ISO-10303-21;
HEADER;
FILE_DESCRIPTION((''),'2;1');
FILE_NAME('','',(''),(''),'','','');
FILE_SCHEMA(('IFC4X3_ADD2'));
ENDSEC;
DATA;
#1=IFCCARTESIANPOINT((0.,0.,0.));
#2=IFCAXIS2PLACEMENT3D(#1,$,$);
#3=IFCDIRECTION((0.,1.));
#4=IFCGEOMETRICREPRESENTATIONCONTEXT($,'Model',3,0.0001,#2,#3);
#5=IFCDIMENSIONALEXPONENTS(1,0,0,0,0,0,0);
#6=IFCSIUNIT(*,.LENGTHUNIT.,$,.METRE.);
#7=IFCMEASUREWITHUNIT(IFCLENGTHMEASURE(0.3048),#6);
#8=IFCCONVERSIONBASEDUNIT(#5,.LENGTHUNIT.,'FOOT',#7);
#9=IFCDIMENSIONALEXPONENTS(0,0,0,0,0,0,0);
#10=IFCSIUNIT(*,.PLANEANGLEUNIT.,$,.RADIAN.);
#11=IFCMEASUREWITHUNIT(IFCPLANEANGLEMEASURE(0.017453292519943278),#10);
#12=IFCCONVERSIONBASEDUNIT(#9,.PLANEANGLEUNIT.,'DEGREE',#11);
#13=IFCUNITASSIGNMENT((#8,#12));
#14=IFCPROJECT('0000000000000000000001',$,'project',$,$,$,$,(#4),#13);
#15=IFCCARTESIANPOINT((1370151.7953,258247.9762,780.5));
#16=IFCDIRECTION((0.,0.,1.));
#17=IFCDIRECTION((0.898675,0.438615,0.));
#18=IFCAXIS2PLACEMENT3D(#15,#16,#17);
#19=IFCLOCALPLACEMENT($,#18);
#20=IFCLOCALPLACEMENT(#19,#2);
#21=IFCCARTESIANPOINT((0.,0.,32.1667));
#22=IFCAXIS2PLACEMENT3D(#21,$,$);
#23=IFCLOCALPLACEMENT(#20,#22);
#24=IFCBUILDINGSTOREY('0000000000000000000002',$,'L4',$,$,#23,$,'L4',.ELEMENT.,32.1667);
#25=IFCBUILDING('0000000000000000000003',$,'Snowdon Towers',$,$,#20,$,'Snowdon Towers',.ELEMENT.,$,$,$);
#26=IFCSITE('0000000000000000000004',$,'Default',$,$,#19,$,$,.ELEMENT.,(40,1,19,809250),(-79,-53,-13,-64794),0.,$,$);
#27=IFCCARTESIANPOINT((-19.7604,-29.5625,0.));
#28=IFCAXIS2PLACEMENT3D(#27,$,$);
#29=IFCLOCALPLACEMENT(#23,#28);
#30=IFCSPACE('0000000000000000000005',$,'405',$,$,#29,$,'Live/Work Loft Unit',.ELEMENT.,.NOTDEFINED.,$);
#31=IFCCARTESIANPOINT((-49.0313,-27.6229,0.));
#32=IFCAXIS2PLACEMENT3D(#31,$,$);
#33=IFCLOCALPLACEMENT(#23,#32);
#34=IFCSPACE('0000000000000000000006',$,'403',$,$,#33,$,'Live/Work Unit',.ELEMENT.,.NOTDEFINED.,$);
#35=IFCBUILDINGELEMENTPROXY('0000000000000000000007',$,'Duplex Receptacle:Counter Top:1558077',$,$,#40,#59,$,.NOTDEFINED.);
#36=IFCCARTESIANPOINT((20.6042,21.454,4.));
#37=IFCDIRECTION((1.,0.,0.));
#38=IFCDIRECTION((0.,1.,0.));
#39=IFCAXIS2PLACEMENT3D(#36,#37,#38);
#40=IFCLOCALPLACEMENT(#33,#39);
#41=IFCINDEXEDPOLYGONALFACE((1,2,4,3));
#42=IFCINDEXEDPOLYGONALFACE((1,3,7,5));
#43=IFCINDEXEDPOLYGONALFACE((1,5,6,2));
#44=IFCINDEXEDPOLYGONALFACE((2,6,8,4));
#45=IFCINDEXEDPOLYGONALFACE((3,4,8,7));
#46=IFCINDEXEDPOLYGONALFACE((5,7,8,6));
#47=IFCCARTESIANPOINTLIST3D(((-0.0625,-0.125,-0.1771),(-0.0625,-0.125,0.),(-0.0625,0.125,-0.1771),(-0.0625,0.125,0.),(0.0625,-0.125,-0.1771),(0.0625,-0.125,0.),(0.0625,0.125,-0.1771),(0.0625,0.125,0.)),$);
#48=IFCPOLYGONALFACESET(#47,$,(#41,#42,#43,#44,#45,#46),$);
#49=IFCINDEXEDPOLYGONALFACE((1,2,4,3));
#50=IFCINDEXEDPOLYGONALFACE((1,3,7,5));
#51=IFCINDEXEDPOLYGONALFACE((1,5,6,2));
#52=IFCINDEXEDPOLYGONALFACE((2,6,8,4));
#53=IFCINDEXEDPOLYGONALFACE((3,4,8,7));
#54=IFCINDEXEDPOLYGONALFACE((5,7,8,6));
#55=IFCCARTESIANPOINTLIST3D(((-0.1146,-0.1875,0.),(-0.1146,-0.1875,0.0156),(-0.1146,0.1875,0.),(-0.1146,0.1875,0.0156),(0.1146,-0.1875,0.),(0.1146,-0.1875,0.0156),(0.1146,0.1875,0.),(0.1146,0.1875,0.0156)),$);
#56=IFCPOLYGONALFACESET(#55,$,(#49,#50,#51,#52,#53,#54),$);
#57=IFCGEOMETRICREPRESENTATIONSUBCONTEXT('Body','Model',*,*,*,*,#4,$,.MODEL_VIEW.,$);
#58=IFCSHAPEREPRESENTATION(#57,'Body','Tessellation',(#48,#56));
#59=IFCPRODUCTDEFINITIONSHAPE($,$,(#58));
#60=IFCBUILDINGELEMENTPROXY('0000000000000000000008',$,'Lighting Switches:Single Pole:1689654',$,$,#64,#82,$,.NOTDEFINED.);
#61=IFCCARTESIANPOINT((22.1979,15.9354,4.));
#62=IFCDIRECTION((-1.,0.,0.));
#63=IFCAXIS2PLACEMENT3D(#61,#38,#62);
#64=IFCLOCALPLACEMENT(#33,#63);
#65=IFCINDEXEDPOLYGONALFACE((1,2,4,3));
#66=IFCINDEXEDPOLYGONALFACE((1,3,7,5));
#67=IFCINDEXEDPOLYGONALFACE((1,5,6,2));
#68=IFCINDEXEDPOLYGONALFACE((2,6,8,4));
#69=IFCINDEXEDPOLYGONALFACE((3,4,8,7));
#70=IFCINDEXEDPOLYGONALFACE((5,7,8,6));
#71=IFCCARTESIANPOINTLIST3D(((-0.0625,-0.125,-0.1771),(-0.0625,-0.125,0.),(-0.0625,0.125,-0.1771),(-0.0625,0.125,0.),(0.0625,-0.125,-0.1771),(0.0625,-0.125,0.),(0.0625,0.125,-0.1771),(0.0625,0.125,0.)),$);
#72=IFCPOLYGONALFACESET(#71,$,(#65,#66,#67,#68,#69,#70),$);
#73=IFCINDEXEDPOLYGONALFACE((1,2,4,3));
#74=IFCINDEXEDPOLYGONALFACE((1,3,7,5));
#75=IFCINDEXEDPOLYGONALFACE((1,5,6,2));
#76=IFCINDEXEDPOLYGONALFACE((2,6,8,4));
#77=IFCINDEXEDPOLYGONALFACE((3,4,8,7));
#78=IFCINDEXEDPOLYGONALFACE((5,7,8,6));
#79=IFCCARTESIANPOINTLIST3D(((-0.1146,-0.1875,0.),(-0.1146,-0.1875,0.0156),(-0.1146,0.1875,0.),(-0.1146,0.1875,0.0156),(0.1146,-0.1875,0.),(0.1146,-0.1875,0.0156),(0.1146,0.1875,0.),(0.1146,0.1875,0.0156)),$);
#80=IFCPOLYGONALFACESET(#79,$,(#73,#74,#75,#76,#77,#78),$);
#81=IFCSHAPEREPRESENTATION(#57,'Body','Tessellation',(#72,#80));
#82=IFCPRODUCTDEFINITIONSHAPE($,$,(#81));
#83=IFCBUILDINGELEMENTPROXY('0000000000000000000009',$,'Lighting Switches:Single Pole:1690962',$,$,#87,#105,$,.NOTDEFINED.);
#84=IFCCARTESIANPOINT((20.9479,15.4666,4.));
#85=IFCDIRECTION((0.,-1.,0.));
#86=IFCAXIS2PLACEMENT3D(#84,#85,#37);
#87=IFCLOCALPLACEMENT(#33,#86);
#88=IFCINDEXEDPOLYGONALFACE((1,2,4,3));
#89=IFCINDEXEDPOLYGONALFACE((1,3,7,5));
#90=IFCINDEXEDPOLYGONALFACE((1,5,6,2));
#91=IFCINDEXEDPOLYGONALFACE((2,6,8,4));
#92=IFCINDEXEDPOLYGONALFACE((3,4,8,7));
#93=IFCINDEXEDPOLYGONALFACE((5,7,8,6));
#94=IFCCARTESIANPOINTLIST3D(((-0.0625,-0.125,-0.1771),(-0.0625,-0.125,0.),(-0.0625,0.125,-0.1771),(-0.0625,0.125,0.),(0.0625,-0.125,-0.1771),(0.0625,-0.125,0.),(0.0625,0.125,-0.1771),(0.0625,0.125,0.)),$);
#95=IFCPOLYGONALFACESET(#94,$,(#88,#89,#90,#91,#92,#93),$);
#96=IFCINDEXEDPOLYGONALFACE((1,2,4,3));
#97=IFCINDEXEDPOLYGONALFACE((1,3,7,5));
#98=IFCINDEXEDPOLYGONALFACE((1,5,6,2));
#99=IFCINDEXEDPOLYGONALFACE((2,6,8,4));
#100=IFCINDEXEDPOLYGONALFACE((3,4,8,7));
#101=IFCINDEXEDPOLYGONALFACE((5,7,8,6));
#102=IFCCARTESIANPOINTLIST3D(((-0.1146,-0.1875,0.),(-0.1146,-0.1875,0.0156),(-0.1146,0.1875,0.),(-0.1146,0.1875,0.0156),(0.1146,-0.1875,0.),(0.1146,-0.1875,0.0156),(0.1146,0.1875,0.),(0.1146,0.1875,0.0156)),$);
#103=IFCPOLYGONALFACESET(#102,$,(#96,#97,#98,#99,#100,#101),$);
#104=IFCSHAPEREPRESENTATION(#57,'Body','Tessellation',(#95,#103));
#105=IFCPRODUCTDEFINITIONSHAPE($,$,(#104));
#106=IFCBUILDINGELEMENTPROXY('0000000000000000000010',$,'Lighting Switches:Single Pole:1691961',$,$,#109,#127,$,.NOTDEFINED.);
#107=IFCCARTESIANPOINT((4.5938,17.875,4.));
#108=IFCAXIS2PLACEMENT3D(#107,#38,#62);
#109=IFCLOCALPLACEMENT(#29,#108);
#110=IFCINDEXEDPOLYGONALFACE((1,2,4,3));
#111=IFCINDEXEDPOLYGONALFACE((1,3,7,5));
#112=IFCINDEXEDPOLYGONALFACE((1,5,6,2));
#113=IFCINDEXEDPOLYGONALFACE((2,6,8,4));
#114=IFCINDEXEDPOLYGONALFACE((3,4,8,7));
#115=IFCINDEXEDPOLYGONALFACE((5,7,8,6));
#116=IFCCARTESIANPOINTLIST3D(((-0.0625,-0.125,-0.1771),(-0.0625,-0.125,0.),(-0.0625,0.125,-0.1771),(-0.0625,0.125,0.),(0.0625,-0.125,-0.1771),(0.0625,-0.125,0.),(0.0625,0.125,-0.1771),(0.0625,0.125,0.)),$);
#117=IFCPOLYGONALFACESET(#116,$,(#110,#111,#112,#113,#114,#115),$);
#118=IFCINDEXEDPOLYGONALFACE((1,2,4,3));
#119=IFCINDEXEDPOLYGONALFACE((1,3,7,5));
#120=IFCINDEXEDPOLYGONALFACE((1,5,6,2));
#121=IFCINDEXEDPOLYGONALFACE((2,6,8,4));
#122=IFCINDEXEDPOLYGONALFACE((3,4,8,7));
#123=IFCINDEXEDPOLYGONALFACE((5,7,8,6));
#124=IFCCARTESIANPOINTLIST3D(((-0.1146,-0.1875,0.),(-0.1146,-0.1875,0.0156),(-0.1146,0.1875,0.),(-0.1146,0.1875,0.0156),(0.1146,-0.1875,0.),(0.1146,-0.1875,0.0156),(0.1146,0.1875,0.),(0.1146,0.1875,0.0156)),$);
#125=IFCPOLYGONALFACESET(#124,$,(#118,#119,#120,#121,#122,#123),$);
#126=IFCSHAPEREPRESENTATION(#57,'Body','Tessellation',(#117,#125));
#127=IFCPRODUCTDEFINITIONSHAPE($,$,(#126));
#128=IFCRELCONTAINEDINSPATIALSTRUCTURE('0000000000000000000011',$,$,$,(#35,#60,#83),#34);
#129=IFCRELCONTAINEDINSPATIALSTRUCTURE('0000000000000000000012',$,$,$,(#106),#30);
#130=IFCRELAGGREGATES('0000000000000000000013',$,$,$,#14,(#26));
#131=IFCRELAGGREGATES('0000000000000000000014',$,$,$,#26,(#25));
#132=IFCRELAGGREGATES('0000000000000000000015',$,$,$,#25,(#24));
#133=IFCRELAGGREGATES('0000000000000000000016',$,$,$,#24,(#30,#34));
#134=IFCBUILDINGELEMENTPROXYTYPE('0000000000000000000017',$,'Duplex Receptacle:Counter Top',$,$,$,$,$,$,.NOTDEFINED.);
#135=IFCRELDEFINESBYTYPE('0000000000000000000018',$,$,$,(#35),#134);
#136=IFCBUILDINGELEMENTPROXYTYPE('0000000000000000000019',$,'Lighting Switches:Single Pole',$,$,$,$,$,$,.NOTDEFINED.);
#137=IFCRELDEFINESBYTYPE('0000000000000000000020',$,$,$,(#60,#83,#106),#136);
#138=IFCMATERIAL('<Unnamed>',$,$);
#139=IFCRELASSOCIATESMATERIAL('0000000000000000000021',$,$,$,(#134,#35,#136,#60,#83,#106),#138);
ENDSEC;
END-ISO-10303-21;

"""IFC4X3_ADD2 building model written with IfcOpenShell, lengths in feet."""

from ifc_helpers import new_model, entity, si_unit, converted_unit, direction, frame, frame_2d, origin, origin_2d_with_axis, place, context, subcontext, project, spatial, rectangle, extrude, source, transform, mapped, material, type_object, type_shapes, element, save


model = new_model("IFC4X3_ADD2")

# Units and contexts
model_context = context("Model", 3, precision=0.0001, world=origin(), true_north=direction((0.0, 1.0)))
body_context = subcontext(model_context, "Body", "Model", "MODEL_VIEW")
ifc_project = project(units=[converted_unit("LENGTHUNIT", "FOOT", entity("IfcLengthMeasure", 0.3048), si_unit("LENGTHUNIT", "METRE"), dimensions=[1, 0, 0, 0, 0, 0, 0]), converted_unit("PLANEANGLEUNIT", "DEGREE", entity("IfcPlaneAngleMeasure", 0.017453292519943278), si_unit("PLANEANGLEUNIT", "RADIAN"), dimensions=[0, 0, 0, 0, 0, 0, 0])], contexts=[model_context])

# Site, building, storey, space
site_placement = place(None, frame((1370151.7953, 258247.9762, 780.5), z_axis=(0.0, 0.0, 1.0), x_axis=(0.898675, 0.438615, 0.0)))
site = spatial("IfcSite", under=ifc_project, at=site_placement, Name="Default", CompositionType="ELEMENT", RefLatitude=(40, 1, 19, 809250), RefLongitude=(-79, -53, -13, -64794), RefElevation=0.0)
building_placement = place(site_placement, origin())
building = spatial("IfcBuilding", under=site, at=building_placement, Name="Snowdon Towers", LongName="Snowdon Towers", CompositionType="ELEMENT")
storey_placement = place(building_placement, frame((0.0, 0.0, 32.1667)))
storey = spatial("IfcBuildingStorey", under=building, at=storey_placement, Name="L4", LongName="L4", CompositionType="ELEMENT", Elevation=32.1667)
space_1_placement = place(storey_placement, frame((-19.7604, -29.5625, 0.0)))
space_1 = spatial("IfcSpace", under=storey, at=space_1_placement, Name="405", LongName="Live/Work Loft Unit", CompositionType="ELEMENT", PredefinedType="NOTDEFINED")

# Shared definitions
ifc_material_1 = material(Name="<Unnamed>")

# Shared definitions
space_2_placement = place(storey_placement, frame((-49.0313, -27.6229, 0.0)))
space_2 = spatial("IfcSpace", under=storey, at=space_2_placement, Name="403", LongName="Live/Work Unit", CompositionType="ELEMENT", PredefinedType="NOTDEFINED")

# Building element proxies
building_element_proxy_type_1 = type_object("IfcBuildingElementProxyType", Name="Duplex Receptacle:Counter Top", PredefinedType="NOTDEFINED", material=ifc_material_1)
shared_shape_1 = source(origin(), body_context, "Body", "SweptSolid", [
    extrude(rectangle(XDim=0.125, YDim=0.25, at=origin_2d_with_axis()), frame((0.0, 0.0, -0.1771), z_axis=(0.0, 0.0, 1.0), x_axis=(-1.0, 0.0, 0.0)), (0.0, 0.0, 1.0), 0.1771),
    extrude(rectangle(XDim=0.2292, YDim=0.375, at=frame_2d((0.0, 0.0), x_axis=(1.0, 0.0))), frame((0.0, 0.0, 0.0), z_axis=(0.0, 0.0, 1.0), x_axis=(-1.0, 0.0, 0.0)), (0.0, 0.0, 1.0), 0.0156),
])
type_shapes(building_element_proxy_type_1, [shared_shape_1])
proxy_1_placement = place(space_2_placement, frame((20.6042, 21.454, 4.0), z_axis=(1.0, 0.0, 0.0), x_axis=(0.0, 1.0, 0.0)))
element("IfcBuildingElementProxy", 1, at=proxy_1_placement, inside=space_2, type_object=building_element_proxy_type_1, material=ifc_material_1, Name="Duplex Receptacle:Counter Top:1558077", PredefinedType="NOTDEFINED", context=body_context, shape_type="MappedRepresentation", body=[
    mapped(shared_shape_1, transform((0.0, 0.0, 0.0), scale=1.0)),
])
building_element_proxy_type_2 = type_object("IfcBuildingElementProxyType", Name="Lighting Switches:Single Pole", PredefinedType="NOTDEFINED", material=ifc_material_1)
shared_shape_2 = source(origin(), body_context, "Body", "SweptSolid", [
    extrude(rectangle(XDim=0.125, YDim=0.25, at=origin_2d_with_axis()), frame((0.0, 0.0, -0.1771), z_axis=(0.0, 0.0, 1.0), x_axis=(-1.0, 0.0, 0.0)), (0.0, 0.0, 1.0), 0.1771),
    extrude(rectangle(XDim=0.2292, YDim=0.375, at=frame_2d((0.0, 0.0), x_axis=(1.0, 0.0))), frame((0.0, 0.0, 0.0), z_axis=(0.0, 0.0, 1.0), x_axis=(-1.0, 0.0, 0.0)), (0.0, 0.0, 1.0), 0.0156),
])
type_shapes(building_element_proxy_type_2, [shared_shape_2])
for number, where, z_axis, x_axis, name in (
    (2, (22.1979, 15.9354, 4.0), (0.0, 1.0, 0.0), (-1.0, 0.0, 0.0), "Lighting Switches:Single Pole:1689654"),
    (3, (20.9479, 15.4666, 4.0), (0.0, -1.0, 0.0), (1.0, 0.0, 0.0), "Lighting Switches:Single Pole:1690962"),
):
    element("IfcBuildingElementProxy", number, at=place(space_2_placement, frame(where, z_axis=z_axis, x_axis=x_axis)), inside=space_2, type_object=building_element_proxy_type_2, material=ifc_material_1, Name=name, PredefinedType="NOTDEFINED", context=body_context, shape_type="MappedRepresentation", body=[
        mapped(shared_shape_2, transform((0.0, 0.0, 0.0), scale=1.0)),
    ])
for number, where, z_axis, x_axis, name in (
    (4, (4.5938, 17.875, 4.0), (0.0, 1.0, 0.0), (-1.0, 0.0, 0.0), "Lighting Switches:Single Pole:1691961"),
):
    element("IfcBuildingElementProxy", number, at=place(space_1_placement, frame(where, z_axis=z_axis, x_axis=x_axis)), inside=space_1, type_object=building_element_proxy_type_2, material=ifc_material_1, Name=name, PredefinedType="NOTDEFINED", context=body_context, shape_type="MappedRepresentation", body=[
        mapped(shared_shape_2, transform((0.0, 0.0, 0.0), scale=1.0)),
    ])

save(model, "model.ifc")
